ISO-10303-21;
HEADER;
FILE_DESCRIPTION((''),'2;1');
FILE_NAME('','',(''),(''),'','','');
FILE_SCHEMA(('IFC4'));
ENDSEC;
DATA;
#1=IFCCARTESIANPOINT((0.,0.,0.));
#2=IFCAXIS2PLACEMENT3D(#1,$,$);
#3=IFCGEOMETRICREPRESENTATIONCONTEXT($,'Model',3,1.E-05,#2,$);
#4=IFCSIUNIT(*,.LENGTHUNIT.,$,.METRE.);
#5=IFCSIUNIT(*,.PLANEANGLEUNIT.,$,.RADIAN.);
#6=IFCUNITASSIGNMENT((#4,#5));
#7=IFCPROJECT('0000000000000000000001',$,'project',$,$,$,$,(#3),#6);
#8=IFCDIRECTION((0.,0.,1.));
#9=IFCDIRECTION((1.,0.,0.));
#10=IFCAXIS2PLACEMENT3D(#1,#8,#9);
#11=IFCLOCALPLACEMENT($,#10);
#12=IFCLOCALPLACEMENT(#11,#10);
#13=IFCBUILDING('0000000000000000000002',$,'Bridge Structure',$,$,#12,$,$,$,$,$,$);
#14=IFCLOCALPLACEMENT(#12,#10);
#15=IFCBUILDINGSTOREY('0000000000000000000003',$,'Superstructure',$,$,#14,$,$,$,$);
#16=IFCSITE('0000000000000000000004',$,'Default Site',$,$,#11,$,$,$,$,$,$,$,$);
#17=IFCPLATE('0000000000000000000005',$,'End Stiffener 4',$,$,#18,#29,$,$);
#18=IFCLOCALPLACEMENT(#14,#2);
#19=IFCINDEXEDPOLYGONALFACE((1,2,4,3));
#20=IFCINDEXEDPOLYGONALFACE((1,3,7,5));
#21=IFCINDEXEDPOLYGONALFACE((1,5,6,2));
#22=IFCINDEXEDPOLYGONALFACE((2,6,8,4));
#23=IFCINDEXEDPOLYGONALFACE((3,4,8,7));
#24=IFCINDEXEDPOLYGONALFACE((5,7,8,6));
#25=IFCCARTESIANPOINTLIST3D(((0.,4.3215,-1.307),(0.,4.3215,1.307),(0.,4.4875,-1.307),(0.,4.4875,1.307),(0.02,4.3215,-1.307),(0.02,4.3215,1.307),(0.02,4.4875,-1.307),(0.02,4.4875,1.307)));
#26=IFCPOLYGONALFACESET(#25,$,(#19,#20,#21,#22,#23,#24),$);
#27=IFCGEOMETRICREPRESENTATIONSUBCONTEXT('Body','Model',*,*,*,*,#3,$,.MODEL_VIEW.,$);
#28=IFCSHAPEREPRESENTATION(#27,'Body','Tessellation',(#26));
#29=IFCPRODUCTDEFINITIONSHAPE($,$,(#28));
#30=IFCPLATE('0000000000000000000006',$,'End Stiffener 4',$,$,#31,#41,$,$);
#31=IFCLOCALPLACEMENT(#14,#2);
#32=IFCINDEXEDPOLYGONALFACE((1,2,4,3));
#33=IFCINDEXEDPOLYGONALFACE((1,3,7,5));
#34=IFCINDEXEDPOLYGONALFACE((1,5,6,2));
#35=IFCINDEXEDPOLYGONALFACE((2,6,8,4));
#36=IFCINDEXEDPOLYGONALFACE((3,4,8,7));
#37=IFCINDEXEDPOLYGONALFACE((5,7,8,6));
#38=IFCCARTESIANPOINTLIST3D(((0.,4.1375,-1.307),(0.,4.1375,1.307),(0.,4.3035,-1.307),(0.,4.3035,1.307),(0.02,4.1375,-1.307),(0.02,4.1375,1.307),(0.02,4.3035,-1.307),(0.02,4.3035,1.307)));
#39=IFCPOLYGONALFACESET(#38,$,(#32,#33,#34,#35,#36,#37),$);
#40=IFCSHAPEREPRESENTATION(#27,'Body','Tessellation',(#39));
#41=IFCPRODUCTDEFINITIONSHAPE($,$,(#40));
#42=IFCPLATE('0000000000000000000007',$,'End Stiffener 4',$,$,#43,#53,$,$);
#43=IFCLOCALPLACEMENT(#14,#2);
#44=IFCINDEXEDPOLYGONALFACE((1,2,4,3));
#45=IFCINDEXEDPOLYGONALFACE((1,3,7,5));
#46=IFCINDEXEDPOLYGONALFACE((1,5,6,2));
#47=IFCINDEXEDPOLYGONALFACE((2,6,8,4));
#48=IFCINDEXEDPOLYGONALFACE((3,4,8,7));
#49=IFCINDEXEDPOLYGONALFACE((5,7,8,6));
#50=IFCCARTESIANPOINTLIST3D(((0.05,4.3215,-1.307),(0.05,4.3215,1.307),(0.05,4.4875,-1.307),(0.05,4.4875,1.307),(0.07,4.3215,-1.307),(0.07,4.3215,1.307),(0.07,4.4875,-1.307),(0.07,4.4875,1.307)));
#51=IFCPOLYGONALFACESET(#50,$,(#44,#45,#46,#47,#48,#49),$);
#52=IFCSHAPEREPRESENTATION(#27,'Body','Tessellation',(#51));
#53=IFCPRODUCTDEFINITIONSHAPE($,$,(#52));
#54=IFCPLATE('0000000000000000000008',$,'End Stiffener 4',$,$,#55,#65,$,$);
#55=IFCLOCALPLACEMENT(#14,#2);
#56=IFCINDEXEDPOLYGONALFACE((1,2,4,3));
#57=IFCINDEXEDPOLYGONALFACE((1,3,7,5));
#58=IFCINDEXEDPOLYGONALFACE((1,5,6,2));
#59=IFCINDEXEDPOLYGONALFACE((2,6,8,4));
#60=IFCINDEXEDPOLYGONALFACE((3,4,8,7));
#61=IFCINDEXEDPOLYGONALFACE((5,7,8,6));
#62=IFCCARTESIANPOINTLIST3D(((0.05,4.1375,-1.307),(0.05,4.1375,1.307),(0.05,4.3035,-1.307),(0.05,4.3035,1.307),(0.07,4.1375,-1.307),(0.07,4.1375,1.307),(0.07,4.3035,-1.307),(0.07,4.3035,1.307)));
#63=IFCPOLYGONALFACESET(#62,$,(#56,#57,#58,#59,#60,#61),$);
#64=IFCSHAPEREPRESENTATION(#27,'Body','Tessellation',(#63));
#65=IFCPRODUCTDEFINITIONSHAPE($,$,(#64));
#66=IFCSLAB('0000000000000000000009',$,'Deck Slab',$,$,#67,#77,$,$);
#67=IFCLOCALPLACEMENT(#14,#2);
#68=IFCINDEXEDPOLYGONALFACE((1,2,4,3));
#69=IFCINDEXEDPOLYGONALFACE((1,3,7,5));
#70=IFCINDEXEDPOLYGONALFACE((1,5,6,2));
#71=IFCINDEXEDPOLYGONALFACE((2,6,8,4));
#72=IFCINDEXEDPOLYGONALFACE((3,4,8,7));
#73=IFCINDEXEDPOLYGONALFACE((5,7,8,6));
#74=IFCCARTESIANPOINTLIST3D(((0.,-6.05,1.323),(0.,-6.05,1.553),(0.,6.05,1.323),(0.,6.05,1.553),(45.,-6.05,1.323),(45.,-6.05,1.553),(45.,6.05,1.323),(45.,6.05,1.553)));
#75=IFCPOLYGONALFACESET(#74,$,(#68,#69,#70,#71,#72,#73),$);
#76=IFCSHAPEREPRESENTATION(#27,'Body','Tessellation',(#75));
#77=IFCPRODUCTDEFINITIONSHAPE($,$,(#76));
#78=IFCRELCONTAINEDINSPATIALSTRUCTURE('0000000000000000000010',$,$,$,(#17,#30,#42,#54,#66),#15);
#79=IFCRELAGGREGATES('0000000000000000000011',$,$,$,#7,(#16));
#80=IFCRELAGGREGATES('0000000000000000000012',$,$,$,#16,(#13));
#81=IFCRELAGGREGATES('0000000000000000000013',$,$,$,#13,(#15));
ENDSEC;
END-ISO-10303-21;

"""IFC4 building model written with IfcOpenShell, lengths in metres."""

from ifc_helpers import new_model, si_unit, frame, origin, origin_with_axes, origin_2d_with_axis, place, context, subcontext, project, spatial, polyline, rectangle, outline, extrude, element, save


model = new_model("IFC4")

# Units and contexts
model_context = context("Model", 3, precision=1e-05, world=origin())
body_context = subcontext(model_context, "Body", "Model", "MODEL_VIEW")
ifc_project = project(units=[si_unit("LENGTHUNIT", "METRE"), si_unit("PLANEANGLEUNIT", "RADIAN")], contexts=[model_context])

# Site, building, storey
site_placement = place(None, origin_with_axes())
site = spatial("IfcSite", under=ifc_project, at=site_placement, Name="Default Site")
building_placement = place(site_placement, origin_with_axes())
building = spatial("IfcBuilding", under=site, at=building_placement, Name="Bridge Structure")
storey_placement = place(building_placement, origin_with_axes())
storey = spatial("IfcBuildingStorey", under=building, at=storey_placement, Name="Superstructure")

# Plates
for number, where, z_axis, x_axis, name in (
    (1, (0.01, 4.4045, -1.307), (0.0, 0.0, 1.0), (1.0, 0.0, 0.0), "End Stiffener 4"),
    (2, (0.01, 4.2205, -1.307), (0.0, 0.0, 1.0), (1.0, 0.0, 0.0), "End Stiffener 4"),
    (3, (0.06, 4.4045, -1.307), (0.0, 0.0, 1.0), (1.0, 0.0, 0.0), "End Stiffener 4"),
    (4, (0.06, 4.2205, -1.307), (0.0, 0.0, 1.0), (1.0, 0.0, 0.0), "End Stiffener 4"),
):
    element("IfcPlate", number, at=place(storey_placement, frame(where, z_axis=z_axis, x_axis=x_axis)), inside=storey, Name=name, context=body_context, shape_type="SweptSolid", body=[
        extrude(rectangle(XDim=0.02, YDim=0.166, at=origin_2d_with_axis()), origin_with_axes(), (0.0, 0.0, 1.0), 2.614),
    ])

# Slab
slab_placement = place(storey_placement, frame((0.0, 0.0, 1.323), z_axis=(0.0, 0.0, 1.0), x_axis=(1.0, 0.0, 0.0)))
element("IfcSlab", 5, at=slab_placement, inside=storey, Name="Deck Slab", context=body_context, shape_type="SweptSolid", body=[
    extrude(outline(polyline([(0.0, -6.05), (45.0, -6.05), (45.0, 6.05), (0.0, 6.05), (0.0, -6.05)])), origin_with_axes(), (0.0, 0.0, 1.0), 0.23),
])

save(model, "model.ifc")
